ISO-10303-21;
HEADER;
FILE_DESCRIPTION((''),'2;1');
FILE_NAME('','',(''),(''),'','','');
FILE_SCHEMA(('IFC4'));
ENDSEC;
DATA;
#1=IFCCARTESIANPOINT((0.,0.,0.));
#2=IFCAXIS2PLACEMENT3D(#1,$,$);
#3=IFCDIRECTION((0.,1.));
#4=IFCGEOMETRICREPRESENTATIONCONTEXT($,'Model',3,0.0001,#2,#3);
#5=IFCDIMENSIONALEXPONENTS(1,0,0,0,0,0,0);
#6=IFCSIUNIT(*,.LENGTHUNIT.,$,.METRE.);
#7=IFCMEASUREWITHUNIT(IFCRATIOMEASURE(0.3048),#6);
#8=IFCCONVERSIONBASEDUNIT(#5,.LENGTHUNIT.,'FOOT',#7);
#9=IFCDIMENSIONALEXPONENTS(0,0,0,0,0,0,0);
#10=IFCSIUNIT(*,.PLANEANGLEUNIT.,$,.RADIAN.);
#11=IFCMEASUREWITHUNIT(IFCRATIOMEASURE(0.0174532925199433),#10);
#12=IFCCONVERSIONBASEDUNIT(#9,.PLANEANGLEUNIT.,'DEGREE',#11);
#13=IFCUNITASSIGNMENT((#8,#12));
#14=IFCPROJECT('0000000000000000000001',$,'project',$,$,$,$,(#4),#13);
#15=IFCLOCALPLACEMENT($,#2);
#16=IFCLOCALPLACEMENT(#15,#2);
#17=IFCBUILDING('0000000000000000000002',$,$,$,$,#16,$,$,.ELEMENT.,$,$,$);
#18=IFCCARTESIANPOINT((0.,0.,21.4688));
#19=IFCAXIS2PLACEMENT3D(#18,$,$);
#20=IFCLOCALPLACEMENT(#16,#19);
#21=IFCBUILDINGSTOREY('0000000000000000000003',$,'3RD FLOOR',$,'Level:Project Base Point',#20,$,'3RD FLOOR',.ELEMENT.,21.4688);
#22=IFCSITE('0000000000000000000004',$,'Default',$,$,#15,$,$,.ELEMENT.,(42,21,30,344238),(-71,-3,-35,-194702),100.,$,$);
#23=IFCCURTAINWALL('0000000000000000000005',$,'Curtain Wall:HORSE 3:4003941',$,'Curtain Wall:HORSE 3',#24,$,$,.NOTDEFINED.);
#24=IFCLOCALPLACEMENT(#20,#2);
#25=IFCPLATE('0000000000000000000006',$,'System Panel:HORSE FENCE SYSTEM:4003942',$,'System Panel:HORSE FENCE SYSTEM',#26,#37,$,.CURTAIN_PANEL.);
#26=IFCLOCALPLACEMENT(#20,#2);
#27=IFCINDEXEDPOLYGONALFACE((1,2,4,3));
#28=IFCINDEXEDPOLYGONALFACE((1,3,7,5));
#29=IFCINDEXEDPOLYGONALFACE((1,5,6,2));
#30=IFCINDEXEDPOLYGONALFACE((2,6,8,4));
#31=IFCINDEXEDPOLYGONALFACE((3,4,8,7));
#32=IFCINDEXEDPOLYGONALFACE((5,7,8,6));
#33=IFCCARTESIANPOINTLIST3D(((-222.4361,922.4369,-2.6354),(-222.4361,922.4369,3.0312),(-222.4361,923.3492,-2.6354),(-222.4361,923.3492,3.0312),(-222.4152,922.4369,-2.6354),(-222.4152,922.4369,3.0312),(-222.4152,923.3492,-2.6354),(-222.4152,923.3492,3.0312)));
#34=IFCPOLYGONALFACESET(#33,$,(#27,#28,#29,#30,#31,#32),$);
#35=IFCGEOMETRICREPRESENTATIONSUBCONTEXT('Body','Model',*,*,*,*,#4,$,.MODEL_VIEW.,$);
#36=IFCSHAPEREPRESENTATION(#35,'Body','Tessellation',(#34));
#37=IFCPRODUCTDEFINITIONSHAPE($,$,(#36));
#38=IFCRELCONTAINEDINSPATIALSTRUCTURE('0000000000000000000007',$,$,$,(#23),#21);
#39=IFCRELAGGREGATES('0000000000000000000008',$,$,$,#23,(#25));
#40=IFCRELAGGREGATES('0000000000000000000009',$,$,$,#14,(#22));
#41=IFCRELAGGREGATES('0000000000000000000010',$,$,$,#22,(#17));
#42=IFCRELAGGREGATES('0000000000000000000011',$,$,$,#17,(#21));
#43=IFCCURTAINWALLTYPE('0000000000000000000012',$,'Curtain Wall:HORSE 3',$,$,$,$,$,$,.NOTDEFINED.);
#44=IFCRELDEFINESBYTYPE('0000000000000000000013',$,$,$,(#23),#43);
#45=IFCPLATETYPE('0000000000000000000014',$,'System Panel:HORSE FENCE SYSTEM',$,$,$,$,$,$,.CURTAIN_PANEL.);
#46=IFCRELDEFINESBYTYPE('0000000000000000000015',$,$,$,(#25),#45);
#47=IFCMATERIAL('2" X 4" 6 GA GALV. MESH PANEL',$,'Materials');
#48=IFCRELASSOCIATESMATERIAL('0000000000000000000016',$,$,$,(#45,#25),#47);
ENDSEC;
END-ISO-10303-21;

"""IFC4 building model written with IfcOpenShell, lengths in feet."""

from ifc_helpers import new_model, entity, si_unit, converted_unit, direction, frame, frame_2d, origin, place, context, subcontext, project, spatial, rectangle, extrude, source, transform, mapped, material, type_object, type_shapes, element, aggregate, save


model = new_model("IFC4")

# Units and contexts
model_context = context("Model", 3, precision=0.0001, world=origin(), true_north=direction((0.0, 1.0)))
body_context = subcontext(model_context, "Body", "Model", "MODEL_VIEW")
ifc_project = project(units=[converted_unit("LENGTHUNIT", "FOOT", entity("IfcRatioMeasure", 0.3048), si_unit("LENGTHUNIT", "METRE"), dimensions=[1, 0, 0, 0, 0, 0, 0]), converted_unit("PLANEANGLEUNIT", "DEGREE", entity("IfcRatioMeasure", 0.0174532925199433), si_unit("PLANEANGLEUNIT", "RADIAN"), dimensions=[0, 0, 0, 0, 0, 0, 0])], contexts=[model_context])

# Site, building, storey
site_placement = place(None, origin())
site = spatial("IfcSite", under=ifc_project, at=site_placement, Name="Default", CompositionType="ELEMENT", RefLatitude=(42, 21, 30, 344238), RefLongitude=(-71, -3, -35, -194702), RefElevation=100.0)
building_placement = place(site_placement, origin())
building = spatial("IfcBuilding", under=site, at=building_placement, CompositionType="ELEMENT")
storey_placement = place(building_placement, frame((0.0, 0.0, 21.4688)))
storey = spatial("IfcBuildingStorey", under=building, at=storey_placement, Name="3RD FLOOR", ObjectType="Level:Project Base Point", LongName="3RD FLOOR", CompositionType="ELEMENT", Elevation=21.4688)

# Shared definitions
curtain_wall_type = type_object("IfcCurtainWallType", Name="Curtain Wall:HORSE 3", PredefinedType="NOTDEFINED")

# Curtain wall
curtain_wall_1_placement = place(storey_placement, frame((0.0, 0.0, -21.4688)))
curtain_wall_1 = element("IfcCurtainWall", 1, at=curtain_wall_1_placement, inside=storey, type_object=curtain_wall_type, Name="Curtain Wall:HORSE 3:4003941", ObjectType="Curtain Wall:HORSE 3", PredefinedType="NOTDEFINED")

# Plate
ifc_material_1 = material(Name="2\" X 4\" 6 GA GALV. MESH PANEL", Category="Materials")
plate_type_1 = type_object("IfcPlateType", Name="System Panel:HORSE FENCE SYSTEM", PredefinedType="CURTAIN_PANEL", material=ifc_material_1)
shared_shape_1 = source(origin(), body_context, "Body", "SweptSolid", [
    extrude(rectangle(XDim=0.0208, YDim=0.9123, at=frame_2d((0.0, 0.0), x_axis=(1.0, 0.0))), frame((0.4561, 0.0104, 0.0), z_axis=(0.0, 0.0, 1.0), x_axis=(0.0, 1.0, 0.0)), (0.0, 0.0, 1.0), 5.6667),
])
type_shapes(plate_type_1, [shared_shape_1])
plate_1_placement = place(curtain_wall_1_placement, frame((-222.4361, 923.3492, 18.8333), z_axis=(0.0, 0.0, 1.0), x_axis=(0.0, -1.0, 0.0)))
plate_1 = element("IfcPlate", 2, at=plate_1_placement, type_object=plate_type_1, material=ifc_material_1, Name="System Panel:HORSE FENCE SYSTEM:4003942", ObjectType="System Panel:HORSE FENCE SYSTEM", PredefinedType="CURTAIN_PANEL", context=body_context, shape_type="MappedRepresentation", body=[
    mapped(shared_shape_1, transform((0.0, 0.0, 0.0), scale=1.0)),
])
aggregate(curtain_wall_1, [plate_1])

save(model, "model.ifc")
